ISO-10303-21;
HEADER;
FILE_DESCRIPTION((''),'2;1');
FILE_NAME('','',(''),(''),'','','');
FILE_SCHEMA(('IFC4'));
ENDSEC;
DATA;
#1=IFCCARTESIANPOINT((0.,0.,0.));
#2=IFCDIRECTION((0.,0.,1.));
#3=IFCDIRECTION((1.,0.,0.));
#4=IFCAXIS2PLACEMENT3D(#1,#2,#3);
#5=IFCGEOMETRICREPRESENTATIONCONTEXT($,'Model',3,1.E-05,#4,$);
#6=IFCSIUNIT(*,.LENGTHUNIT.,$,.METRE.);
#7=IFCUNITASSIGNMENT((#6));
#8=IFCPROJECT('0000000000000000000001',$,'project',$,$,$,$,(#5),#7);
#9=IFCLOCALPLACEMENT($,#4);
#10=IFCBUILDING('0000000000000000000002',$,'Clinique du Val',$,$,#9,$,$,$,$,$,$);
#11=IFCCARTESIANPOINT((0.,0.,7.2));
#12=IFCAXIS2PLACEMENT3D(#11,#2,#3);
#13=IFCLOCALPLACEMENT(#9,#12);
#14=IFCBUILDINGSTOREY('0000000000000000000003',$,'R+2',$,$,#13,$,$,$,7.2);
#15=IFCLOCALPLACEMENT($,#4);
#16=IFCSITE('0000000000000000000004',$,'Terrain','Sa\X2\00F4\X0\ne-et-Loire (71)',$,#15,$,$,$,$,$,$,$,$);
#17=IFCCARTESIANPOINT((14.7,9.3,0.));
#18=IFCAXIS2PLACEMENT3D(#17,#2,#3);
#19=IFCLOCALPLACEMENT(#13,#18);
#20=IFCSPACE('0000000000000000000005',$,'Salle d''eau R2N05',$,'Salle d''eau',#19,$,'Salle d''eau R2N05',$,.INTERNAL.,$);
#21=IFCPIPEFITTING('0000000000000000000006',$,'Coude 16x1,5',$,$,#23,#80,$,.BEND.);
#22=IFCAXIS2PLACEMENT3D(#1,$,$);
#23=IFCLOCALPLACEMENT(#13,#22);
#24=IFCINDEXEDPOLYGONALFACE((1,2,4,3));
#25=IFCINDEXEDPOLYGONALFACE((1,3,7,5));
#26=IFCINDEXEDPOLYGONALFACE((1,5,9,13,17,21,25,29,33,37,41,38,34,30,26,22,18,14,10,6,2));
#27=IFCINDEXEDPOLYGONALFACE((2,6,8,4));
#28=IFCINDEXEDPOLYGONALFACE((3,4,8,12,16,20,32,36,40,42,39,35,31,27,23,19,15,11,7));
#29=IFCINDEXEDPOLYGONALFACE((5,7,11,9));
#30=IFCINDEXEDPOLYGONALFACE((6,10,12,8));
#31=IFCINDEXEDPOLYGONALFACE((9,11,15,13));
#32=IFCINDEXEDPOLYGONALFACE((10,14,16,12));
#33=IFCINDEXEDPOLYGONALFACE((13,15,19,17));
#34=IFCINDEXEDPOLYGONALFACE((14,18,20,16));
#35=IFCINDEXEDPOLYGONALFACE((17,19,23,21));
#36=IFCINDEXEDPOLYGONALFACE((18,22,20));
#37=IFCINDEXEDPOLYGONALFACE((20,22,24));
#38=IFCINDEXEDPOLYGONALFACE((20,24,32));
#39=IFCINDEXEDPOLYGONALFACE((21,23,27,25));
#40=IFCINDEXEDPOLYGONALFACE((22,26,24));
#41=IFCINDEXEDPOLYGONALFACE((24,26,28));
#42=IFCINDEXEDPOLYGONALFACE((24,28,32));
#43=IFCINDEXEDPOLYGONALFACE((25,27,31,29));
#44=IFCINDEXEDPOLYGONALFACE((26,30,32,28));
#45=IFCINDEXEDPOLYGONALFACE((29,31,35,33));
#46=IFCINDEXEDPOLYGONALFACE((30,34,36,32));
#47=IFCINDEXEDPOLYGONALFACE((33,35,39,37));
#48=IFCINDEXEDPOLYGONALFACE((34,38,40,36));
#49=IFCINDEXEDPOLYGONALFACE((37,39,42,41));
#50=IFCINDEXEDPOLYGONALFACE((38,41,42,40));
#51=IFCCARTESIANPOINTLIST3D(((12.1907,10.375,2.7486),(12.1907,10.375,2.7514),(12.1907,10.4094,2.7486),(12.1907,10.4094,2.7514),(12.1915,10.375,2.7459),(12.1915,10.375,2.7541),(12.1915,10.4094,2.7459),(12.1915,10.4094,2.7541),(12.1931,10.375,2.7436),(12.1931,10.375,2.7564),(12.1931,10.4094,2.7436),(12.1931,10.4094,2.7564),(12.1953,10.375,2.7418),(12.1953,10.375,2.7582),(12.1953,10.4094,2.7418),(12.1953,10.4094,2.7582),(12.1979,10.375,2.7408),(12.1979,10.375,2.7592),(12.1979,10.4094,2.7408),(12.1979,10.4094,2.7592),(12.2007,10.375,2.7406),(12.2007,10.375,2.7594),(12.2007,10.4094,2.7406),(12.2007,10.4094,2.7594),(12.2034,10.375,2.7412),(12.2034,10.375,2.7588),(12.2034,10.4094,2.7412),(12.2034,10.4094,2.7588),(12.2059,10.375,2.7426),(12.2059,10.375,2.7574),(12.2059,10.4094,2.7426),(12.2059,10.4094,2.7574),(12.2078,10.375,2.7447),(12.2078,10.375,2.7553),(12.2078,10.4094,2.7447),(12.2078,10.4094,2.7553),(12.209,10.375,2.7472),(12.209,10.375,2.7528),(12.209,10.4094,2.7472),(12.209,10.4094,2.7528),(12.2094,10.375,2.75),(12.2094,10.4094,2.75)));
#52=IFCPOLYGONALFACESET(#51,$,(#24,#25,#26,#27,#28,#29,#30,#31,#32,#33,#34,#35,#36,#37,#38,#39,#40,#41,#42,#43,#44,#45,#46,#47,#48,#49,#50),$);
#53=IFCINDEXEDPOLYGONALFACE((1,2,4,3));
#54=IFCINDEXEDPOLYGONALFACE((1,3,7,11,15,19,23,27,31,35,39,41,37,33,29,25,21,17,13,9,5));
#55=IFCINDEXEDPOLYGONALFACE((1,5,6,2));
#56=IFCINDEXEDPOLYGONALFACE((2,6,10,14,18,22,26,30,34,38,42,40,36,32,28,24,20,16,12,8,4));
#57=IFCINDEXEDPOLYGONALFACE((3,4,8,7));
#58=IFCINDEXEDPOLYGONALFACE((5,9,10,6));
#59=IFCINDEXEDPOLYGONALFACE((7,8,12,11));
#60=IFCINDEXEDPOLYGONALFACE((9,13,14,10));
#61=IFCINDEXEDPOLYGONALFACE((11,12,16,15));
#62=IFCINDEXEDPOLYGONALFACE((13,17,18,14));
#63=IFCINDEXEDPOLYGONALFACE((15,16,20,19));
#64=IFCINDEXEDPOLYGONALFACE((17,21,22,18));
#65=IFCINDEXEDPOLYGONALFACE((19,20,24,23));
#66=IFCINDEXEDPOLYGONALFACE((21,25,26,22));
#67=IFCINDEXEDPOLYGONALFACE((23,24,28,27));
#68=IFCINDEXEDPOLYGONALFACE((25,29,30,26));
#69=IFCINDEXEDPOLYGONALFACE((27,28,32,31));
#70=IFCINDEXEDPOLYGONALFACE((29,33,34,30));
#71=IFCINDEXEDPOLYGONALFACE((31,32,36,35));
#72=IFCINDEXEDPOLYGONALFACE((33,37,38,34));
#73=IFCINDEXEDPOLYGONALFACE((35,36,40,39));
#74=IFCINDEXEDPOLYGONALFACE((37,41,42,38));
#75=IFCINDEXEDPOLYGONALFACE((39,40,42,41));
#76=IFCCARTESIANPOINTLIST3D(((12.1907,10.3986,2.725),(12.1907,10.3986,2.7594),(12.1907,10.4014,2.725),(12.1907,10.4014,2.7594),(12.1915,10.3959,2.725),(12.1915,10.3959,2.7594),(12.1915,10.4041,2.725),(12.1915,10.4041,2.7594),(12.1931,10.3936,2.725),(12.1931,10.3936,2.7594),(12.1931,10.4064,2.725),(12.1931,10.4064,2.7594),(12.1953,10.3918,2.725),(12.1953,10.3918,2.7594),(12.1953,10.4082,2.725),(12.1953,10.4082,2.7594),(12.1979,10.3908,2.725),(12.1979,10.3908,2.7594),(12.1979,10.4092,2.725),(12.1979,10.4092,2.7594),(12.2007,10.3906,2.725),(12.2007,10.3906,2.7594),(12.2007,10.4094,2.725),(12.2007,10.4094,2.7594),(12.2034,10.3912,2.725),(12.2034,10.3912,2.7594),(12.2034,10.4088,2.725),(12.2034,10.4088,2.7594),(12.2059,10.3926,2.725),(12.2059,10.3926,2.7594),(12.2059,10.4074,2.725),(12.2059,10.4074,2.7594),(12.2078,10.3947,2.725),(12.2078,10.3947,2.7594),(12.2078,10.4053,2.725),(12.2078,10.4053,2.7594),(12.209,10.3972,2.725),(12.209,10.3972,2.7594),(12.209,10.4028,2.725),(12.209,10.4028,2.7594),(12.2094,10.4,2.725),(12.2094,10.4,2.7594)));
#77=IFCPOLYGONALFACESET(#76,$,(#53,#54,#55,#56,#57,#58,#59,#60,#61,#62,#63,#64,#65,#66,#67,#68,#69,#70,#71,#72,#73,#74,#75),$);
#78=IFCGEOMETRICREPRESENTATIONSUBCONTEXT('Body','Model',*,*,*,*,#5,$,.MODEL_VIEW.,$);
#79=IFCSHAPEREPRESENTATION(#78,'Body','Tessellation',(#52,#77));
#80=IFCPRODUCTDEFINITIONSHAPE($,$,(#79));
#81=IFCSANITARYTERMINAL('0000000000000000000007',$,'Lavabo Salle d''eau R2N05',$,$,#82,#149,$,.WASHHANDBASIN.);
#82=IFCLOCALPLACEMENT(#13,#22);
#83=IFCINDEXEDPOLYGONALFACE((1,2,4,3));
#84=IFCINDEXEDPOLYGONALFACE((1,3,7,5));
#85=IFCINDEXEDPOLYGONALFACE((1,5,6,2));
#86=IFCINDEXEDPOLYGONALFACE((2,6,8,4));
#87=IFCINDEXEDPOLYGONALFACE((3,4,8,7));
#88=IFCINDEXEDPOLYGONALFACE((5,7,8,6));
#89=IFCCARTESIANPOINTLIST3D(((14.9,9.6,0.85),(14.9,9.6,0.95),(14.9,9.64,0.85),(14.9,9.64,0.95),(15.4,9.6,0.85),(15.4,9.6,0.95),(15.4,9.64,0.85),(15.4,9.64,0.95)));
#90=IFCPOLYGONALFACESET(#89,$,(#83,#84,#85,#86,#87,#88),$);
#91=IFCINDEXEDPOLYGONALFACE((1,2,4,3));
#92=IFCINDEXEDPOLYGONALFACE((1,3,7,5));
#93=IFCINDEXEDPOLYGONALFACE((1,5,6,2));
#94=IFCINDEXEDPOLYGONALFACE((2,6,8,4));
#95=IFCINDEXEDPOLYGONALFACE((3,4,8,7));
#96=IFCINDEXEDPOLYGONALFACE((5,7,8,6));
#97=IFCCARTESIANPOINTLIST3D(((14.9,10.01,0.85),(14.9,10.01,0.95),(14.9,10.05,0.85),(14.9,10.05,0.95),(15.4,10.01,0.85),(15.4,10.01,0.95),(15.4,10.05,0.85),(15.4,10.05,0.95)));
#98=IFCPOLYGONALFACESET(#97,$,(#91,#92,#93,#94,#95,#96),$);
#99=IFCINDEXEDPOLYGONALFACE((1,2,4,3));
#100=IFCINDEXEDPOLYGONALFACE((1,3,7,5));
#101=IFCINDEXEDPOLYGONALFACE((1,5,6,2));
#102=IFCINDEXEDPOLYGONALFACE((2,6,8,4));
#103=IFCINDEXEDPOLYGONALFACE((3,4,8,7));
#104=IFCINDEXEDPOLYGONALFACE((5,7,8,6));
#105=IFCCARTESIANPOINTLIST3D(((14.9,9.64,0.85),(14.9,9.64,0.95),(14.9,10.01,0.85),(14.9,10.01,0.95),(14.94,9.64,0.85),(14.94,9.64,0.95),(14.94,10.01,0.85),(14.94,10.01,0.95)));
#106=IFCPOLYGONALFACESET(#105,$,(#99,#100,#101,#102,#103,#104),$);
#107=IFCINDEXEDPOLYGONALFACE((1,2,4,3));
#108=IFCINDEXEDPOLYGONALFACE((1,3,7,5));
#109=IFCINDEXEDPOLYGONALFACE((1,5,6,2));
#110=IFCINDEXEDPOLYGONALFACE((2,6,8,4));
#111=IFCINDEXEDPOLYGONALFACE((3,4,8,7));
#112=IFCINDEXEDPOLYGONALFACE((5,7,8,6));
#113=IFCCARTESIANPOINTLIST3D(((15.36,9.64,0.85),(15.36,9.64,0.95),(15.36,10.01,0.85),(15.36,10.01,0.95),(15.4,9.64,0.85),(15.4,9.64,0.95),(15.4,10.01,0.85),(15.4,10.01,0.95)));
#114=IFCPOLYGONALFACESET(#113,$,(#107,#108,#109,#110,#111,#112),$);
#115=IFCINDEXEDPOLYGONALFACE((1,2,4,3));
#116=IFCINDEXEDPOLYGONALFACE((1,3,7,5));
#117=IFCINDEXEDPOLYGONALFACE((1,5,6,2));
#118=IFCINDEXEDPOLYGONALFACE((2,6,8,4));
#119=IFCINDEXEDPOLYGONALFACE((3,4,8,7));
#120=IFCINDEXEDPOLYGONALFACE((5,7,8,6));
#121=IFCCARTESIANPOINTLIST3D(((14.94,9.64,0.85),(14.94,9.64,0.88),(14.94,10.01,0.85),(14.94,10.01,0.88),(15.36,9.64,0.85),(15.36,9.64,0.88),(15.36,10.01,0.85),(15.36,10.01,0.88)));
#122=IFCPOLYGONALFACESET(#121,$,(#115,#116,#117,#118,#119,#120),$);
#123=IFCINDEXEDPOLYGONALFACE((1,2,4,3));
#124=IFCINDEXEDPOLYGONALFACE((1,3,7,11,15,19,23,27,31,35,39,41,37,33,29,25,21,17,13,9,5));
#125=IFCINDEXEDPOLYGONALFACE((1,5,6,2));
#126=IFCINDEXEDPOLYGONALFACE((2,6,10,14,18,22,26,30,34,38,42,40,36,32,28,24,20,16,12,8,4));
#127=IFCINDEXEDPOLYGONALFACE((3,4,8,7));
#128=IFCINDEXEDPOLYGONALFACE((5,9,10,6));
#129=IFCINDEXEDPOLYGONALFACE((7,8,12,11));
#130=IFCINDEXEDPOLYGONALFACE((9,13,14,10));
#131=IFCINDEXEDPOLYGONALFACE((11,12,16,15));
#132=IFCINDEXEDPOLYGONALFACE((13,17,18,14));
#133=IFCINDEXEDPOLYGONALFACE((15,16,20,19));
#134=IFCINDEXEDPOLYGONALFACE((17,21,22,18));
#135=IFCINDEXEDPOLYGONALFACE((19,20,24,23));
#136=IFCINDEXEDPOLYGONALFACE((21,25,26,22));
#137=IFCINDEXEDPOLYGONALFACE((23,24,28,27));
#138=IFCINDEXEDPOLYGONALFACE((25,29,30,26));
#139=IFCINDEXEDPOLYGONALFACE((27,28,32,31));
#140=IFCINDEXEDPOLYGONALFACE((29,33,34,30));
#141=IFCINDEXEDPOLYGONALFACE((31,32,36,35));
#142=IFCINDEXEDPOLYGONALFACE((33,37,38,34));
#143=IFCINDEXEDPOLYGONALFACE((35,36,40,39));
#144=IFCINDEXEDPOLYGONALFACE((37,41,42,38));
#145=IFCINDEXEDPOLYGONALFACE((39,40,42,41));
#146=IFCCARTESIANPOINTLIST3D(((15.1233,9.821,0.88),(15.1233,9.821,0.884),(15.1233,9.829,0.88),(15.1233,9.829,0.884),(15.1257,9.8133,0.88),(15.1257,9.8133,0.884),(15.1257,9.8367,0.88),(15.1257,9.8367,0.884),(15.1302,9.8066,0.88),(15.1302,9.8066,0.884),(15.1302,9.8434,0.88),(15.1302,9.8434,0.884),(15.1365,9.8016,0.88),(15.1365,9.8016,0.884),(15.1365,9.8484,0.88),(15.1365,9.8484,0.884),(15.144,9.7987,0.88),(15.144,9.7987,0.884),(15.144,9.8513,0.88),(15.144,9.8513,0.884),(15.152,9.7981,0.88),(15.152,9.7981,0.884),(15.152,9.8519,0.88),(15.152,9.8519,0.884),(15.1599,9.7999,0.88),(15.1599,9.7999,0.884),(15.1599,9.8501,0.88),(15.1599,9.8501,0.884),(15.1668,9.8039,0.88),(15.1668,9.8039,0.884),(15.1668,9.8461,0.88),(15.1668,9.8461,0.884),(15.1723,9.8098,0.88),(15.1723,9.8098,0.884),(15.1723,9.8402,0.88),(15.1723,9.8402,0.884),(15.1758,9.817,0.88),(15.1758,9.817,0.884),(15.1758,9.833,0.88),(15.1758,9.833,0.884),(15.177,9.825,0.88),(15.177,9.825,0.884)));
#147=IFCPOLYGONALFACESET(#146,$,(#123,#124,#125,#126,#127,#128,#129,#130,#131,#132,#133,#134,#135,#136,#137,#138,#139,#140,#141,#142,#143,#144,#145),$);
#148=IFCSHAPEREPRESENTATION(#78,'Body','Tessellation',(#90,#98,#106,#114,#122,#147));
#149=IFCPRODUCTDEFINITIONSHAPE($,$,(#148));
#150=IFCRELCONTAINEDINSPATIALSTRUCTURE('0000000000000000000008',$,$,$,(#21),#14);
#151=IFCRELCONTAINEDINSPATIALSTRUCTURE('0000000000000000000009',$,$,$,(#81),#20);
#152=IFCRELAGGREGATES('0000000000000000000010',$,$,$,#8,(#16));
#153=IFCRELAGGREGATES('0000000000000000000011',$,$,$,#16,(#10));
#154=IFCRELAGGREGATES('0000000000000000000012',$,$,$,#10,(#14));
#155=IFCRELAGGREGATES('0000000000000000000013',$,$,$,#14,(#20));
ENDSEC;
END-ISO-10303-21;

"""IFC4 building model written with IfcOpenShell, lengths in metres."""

from ifc_helpers import new_model, si_unit, frame, frame_2d, origin_with_axes, place, context, subcontext, project, spatial, rectangle, circle, extrude, element, save


model = new_model("IFC4")

# Units and contexts
model_context = context("Model", 3, precision=1e-05, world=origin_with_axes())
body_context = subcontext(model_context, "Body", "Model", "MODEL_VIEW")
ifc_project = project(units=[si_unit("LENGTHUNIT", "METRE")], contexts=[model_context])

# Site, building, storey
site_placement = place(None, origin_with_axes())
site = spatial("IfcSite", under=ifc_project, at=site_placement, Name="Terrain", Description="Saône-et-Loire (71)")
building_placement = place(None, origin_with_axes())
building = spatial("IfcBuilding", under=site, at=building_placement, Name="Clinique du Val")
storey_placement = place(building_placement, frame((0.0, 0.0, 7.2), z_axis=(0.0, 0.0, 1.0), x_axis=(1.0, 0.0, 0.0)))
storey = spatial("IfcBuildingStorey", under=building, at=storey_placement, Name="R+2", Elevation=7.2)

# Pipe fitting
for number, where, z_axis, x_axis, name in (
    (1, (12.2, 10.4, 2.75), (0.0, 0.0, 1.0), (1.0, 0.0, 0.0), "Coude 16x1,5"),
):
    element("IfcPipeFitting", number, at=place(storey_placement, frame(where, z_axis=z_axis, x_axis=x_axis)), inside=storey, Name=name, PredefinedType="BEND", context=body_context, shape_type="SweptSolid", body=[
        extrude(circle(Radius=0.0094), frame((0.0, 0.0094, 0.0), z_axis=(0.0, -1.0, 0.0), x_axis=(1.0, 0.0, 0.0)), (0.0, 0.0, 1.0), 0.0344),
        extrude(circle(Radius=0.0094), frame((0.0, 0.0, 0.0094), z_axis=(0.0, 0.0, -1.0), x_axis=(1.0, 0.0, 0.0)), (0.0, 0.0, 1.0), 0.0344),
    ])

# Shared definitions
space_1_placement = place(storey_placement, frame((14.7, 9.3, 0.0), z_axis=(0.0, 0.0, 1.0), x_axis=(1.0, 0.0, 0.0)))
space_1 = spatial("IfcSpace", under=storey, at=space_1_placement, Name="Salle d'eau R2N05", ObjectType="Salle d'eau", LongName="Salle d'eau R2N05", PredefinedType="INTERNAL")

# Sanitary terminal
sanitary_terminal_1_placement = place(space_1_placement, frame((0.2, 0.3, 0.85), z_axis=(0.0, 0.0, 1.0), x_axis=(1.0, 0.0, 0.0)))
element("IfcSanitaryTerminal", 2, at=sanitary_terminal_1_placement, inside=space_1, Name="Lavabo Salle d'eau R2N05", PredefinedType="WASHHANDBASIN", context=body_context, shape_type="SweptSolid", body=[
    extrude(rectangle(XDim=0.5, YDim=0.04, at=frame_2d((0.25, 0.02))), origin_with_axes(), (0.0, 0.0, 1.0), 0.1),
    extrude(rectangle(XDim=0.5, YDim=0.04, at=frame_2d((0.25, 0.02))), frame((0.0, 0.41, 0.0), z_axis=(0.0, 0.0, 1.0), x_axis=(1.0, 0.0, 0.0)), (0.0, 0.0, 1.0), 0.1),
    extrude(rectangle(XDim=0.04, YDim=0.37, at=frame_2d((0.02, 0.185))), frame((0.0, 0.04, 0.0), z_axis=(0.0, 0.0, 1.0), x_axis=(1.0, 0.0, 0.0)), (0.0, 0.0, 1.0), 0.1),
    extrude(rectangle(XDim=0.04, YDim=0.37, at=frame_2d((0.02, 0.185))), frame((0.46, 0.04, 0.0), z_axis=(0.0, 0.0, 1.0), x_axis=(1.0, 0.0, 0.0)), (0.0, 0.0, 1.0), 0.1),
    extrude(rectangle(XDim=0.42, YDim=0.37, at=frame_2d((0.21, 0.185))), frame((0.04, 0.04, 0.0), z_axis=(0.0, 0.0, 1.0), x_axis=(1.0, 0.0, 0.0)), (0.0, 0.0, 1.0), 0.03),
    extrude(circle(Radius=0.027), frame((0.25, 0.225, 0.03), z_axis=(0.0, 0.0, 1.0), x_axis=(1.0, 0.0, 0.0)), (0.0, 0.0, 1.0), 0.004),
])

save(model, "model.ifc")
